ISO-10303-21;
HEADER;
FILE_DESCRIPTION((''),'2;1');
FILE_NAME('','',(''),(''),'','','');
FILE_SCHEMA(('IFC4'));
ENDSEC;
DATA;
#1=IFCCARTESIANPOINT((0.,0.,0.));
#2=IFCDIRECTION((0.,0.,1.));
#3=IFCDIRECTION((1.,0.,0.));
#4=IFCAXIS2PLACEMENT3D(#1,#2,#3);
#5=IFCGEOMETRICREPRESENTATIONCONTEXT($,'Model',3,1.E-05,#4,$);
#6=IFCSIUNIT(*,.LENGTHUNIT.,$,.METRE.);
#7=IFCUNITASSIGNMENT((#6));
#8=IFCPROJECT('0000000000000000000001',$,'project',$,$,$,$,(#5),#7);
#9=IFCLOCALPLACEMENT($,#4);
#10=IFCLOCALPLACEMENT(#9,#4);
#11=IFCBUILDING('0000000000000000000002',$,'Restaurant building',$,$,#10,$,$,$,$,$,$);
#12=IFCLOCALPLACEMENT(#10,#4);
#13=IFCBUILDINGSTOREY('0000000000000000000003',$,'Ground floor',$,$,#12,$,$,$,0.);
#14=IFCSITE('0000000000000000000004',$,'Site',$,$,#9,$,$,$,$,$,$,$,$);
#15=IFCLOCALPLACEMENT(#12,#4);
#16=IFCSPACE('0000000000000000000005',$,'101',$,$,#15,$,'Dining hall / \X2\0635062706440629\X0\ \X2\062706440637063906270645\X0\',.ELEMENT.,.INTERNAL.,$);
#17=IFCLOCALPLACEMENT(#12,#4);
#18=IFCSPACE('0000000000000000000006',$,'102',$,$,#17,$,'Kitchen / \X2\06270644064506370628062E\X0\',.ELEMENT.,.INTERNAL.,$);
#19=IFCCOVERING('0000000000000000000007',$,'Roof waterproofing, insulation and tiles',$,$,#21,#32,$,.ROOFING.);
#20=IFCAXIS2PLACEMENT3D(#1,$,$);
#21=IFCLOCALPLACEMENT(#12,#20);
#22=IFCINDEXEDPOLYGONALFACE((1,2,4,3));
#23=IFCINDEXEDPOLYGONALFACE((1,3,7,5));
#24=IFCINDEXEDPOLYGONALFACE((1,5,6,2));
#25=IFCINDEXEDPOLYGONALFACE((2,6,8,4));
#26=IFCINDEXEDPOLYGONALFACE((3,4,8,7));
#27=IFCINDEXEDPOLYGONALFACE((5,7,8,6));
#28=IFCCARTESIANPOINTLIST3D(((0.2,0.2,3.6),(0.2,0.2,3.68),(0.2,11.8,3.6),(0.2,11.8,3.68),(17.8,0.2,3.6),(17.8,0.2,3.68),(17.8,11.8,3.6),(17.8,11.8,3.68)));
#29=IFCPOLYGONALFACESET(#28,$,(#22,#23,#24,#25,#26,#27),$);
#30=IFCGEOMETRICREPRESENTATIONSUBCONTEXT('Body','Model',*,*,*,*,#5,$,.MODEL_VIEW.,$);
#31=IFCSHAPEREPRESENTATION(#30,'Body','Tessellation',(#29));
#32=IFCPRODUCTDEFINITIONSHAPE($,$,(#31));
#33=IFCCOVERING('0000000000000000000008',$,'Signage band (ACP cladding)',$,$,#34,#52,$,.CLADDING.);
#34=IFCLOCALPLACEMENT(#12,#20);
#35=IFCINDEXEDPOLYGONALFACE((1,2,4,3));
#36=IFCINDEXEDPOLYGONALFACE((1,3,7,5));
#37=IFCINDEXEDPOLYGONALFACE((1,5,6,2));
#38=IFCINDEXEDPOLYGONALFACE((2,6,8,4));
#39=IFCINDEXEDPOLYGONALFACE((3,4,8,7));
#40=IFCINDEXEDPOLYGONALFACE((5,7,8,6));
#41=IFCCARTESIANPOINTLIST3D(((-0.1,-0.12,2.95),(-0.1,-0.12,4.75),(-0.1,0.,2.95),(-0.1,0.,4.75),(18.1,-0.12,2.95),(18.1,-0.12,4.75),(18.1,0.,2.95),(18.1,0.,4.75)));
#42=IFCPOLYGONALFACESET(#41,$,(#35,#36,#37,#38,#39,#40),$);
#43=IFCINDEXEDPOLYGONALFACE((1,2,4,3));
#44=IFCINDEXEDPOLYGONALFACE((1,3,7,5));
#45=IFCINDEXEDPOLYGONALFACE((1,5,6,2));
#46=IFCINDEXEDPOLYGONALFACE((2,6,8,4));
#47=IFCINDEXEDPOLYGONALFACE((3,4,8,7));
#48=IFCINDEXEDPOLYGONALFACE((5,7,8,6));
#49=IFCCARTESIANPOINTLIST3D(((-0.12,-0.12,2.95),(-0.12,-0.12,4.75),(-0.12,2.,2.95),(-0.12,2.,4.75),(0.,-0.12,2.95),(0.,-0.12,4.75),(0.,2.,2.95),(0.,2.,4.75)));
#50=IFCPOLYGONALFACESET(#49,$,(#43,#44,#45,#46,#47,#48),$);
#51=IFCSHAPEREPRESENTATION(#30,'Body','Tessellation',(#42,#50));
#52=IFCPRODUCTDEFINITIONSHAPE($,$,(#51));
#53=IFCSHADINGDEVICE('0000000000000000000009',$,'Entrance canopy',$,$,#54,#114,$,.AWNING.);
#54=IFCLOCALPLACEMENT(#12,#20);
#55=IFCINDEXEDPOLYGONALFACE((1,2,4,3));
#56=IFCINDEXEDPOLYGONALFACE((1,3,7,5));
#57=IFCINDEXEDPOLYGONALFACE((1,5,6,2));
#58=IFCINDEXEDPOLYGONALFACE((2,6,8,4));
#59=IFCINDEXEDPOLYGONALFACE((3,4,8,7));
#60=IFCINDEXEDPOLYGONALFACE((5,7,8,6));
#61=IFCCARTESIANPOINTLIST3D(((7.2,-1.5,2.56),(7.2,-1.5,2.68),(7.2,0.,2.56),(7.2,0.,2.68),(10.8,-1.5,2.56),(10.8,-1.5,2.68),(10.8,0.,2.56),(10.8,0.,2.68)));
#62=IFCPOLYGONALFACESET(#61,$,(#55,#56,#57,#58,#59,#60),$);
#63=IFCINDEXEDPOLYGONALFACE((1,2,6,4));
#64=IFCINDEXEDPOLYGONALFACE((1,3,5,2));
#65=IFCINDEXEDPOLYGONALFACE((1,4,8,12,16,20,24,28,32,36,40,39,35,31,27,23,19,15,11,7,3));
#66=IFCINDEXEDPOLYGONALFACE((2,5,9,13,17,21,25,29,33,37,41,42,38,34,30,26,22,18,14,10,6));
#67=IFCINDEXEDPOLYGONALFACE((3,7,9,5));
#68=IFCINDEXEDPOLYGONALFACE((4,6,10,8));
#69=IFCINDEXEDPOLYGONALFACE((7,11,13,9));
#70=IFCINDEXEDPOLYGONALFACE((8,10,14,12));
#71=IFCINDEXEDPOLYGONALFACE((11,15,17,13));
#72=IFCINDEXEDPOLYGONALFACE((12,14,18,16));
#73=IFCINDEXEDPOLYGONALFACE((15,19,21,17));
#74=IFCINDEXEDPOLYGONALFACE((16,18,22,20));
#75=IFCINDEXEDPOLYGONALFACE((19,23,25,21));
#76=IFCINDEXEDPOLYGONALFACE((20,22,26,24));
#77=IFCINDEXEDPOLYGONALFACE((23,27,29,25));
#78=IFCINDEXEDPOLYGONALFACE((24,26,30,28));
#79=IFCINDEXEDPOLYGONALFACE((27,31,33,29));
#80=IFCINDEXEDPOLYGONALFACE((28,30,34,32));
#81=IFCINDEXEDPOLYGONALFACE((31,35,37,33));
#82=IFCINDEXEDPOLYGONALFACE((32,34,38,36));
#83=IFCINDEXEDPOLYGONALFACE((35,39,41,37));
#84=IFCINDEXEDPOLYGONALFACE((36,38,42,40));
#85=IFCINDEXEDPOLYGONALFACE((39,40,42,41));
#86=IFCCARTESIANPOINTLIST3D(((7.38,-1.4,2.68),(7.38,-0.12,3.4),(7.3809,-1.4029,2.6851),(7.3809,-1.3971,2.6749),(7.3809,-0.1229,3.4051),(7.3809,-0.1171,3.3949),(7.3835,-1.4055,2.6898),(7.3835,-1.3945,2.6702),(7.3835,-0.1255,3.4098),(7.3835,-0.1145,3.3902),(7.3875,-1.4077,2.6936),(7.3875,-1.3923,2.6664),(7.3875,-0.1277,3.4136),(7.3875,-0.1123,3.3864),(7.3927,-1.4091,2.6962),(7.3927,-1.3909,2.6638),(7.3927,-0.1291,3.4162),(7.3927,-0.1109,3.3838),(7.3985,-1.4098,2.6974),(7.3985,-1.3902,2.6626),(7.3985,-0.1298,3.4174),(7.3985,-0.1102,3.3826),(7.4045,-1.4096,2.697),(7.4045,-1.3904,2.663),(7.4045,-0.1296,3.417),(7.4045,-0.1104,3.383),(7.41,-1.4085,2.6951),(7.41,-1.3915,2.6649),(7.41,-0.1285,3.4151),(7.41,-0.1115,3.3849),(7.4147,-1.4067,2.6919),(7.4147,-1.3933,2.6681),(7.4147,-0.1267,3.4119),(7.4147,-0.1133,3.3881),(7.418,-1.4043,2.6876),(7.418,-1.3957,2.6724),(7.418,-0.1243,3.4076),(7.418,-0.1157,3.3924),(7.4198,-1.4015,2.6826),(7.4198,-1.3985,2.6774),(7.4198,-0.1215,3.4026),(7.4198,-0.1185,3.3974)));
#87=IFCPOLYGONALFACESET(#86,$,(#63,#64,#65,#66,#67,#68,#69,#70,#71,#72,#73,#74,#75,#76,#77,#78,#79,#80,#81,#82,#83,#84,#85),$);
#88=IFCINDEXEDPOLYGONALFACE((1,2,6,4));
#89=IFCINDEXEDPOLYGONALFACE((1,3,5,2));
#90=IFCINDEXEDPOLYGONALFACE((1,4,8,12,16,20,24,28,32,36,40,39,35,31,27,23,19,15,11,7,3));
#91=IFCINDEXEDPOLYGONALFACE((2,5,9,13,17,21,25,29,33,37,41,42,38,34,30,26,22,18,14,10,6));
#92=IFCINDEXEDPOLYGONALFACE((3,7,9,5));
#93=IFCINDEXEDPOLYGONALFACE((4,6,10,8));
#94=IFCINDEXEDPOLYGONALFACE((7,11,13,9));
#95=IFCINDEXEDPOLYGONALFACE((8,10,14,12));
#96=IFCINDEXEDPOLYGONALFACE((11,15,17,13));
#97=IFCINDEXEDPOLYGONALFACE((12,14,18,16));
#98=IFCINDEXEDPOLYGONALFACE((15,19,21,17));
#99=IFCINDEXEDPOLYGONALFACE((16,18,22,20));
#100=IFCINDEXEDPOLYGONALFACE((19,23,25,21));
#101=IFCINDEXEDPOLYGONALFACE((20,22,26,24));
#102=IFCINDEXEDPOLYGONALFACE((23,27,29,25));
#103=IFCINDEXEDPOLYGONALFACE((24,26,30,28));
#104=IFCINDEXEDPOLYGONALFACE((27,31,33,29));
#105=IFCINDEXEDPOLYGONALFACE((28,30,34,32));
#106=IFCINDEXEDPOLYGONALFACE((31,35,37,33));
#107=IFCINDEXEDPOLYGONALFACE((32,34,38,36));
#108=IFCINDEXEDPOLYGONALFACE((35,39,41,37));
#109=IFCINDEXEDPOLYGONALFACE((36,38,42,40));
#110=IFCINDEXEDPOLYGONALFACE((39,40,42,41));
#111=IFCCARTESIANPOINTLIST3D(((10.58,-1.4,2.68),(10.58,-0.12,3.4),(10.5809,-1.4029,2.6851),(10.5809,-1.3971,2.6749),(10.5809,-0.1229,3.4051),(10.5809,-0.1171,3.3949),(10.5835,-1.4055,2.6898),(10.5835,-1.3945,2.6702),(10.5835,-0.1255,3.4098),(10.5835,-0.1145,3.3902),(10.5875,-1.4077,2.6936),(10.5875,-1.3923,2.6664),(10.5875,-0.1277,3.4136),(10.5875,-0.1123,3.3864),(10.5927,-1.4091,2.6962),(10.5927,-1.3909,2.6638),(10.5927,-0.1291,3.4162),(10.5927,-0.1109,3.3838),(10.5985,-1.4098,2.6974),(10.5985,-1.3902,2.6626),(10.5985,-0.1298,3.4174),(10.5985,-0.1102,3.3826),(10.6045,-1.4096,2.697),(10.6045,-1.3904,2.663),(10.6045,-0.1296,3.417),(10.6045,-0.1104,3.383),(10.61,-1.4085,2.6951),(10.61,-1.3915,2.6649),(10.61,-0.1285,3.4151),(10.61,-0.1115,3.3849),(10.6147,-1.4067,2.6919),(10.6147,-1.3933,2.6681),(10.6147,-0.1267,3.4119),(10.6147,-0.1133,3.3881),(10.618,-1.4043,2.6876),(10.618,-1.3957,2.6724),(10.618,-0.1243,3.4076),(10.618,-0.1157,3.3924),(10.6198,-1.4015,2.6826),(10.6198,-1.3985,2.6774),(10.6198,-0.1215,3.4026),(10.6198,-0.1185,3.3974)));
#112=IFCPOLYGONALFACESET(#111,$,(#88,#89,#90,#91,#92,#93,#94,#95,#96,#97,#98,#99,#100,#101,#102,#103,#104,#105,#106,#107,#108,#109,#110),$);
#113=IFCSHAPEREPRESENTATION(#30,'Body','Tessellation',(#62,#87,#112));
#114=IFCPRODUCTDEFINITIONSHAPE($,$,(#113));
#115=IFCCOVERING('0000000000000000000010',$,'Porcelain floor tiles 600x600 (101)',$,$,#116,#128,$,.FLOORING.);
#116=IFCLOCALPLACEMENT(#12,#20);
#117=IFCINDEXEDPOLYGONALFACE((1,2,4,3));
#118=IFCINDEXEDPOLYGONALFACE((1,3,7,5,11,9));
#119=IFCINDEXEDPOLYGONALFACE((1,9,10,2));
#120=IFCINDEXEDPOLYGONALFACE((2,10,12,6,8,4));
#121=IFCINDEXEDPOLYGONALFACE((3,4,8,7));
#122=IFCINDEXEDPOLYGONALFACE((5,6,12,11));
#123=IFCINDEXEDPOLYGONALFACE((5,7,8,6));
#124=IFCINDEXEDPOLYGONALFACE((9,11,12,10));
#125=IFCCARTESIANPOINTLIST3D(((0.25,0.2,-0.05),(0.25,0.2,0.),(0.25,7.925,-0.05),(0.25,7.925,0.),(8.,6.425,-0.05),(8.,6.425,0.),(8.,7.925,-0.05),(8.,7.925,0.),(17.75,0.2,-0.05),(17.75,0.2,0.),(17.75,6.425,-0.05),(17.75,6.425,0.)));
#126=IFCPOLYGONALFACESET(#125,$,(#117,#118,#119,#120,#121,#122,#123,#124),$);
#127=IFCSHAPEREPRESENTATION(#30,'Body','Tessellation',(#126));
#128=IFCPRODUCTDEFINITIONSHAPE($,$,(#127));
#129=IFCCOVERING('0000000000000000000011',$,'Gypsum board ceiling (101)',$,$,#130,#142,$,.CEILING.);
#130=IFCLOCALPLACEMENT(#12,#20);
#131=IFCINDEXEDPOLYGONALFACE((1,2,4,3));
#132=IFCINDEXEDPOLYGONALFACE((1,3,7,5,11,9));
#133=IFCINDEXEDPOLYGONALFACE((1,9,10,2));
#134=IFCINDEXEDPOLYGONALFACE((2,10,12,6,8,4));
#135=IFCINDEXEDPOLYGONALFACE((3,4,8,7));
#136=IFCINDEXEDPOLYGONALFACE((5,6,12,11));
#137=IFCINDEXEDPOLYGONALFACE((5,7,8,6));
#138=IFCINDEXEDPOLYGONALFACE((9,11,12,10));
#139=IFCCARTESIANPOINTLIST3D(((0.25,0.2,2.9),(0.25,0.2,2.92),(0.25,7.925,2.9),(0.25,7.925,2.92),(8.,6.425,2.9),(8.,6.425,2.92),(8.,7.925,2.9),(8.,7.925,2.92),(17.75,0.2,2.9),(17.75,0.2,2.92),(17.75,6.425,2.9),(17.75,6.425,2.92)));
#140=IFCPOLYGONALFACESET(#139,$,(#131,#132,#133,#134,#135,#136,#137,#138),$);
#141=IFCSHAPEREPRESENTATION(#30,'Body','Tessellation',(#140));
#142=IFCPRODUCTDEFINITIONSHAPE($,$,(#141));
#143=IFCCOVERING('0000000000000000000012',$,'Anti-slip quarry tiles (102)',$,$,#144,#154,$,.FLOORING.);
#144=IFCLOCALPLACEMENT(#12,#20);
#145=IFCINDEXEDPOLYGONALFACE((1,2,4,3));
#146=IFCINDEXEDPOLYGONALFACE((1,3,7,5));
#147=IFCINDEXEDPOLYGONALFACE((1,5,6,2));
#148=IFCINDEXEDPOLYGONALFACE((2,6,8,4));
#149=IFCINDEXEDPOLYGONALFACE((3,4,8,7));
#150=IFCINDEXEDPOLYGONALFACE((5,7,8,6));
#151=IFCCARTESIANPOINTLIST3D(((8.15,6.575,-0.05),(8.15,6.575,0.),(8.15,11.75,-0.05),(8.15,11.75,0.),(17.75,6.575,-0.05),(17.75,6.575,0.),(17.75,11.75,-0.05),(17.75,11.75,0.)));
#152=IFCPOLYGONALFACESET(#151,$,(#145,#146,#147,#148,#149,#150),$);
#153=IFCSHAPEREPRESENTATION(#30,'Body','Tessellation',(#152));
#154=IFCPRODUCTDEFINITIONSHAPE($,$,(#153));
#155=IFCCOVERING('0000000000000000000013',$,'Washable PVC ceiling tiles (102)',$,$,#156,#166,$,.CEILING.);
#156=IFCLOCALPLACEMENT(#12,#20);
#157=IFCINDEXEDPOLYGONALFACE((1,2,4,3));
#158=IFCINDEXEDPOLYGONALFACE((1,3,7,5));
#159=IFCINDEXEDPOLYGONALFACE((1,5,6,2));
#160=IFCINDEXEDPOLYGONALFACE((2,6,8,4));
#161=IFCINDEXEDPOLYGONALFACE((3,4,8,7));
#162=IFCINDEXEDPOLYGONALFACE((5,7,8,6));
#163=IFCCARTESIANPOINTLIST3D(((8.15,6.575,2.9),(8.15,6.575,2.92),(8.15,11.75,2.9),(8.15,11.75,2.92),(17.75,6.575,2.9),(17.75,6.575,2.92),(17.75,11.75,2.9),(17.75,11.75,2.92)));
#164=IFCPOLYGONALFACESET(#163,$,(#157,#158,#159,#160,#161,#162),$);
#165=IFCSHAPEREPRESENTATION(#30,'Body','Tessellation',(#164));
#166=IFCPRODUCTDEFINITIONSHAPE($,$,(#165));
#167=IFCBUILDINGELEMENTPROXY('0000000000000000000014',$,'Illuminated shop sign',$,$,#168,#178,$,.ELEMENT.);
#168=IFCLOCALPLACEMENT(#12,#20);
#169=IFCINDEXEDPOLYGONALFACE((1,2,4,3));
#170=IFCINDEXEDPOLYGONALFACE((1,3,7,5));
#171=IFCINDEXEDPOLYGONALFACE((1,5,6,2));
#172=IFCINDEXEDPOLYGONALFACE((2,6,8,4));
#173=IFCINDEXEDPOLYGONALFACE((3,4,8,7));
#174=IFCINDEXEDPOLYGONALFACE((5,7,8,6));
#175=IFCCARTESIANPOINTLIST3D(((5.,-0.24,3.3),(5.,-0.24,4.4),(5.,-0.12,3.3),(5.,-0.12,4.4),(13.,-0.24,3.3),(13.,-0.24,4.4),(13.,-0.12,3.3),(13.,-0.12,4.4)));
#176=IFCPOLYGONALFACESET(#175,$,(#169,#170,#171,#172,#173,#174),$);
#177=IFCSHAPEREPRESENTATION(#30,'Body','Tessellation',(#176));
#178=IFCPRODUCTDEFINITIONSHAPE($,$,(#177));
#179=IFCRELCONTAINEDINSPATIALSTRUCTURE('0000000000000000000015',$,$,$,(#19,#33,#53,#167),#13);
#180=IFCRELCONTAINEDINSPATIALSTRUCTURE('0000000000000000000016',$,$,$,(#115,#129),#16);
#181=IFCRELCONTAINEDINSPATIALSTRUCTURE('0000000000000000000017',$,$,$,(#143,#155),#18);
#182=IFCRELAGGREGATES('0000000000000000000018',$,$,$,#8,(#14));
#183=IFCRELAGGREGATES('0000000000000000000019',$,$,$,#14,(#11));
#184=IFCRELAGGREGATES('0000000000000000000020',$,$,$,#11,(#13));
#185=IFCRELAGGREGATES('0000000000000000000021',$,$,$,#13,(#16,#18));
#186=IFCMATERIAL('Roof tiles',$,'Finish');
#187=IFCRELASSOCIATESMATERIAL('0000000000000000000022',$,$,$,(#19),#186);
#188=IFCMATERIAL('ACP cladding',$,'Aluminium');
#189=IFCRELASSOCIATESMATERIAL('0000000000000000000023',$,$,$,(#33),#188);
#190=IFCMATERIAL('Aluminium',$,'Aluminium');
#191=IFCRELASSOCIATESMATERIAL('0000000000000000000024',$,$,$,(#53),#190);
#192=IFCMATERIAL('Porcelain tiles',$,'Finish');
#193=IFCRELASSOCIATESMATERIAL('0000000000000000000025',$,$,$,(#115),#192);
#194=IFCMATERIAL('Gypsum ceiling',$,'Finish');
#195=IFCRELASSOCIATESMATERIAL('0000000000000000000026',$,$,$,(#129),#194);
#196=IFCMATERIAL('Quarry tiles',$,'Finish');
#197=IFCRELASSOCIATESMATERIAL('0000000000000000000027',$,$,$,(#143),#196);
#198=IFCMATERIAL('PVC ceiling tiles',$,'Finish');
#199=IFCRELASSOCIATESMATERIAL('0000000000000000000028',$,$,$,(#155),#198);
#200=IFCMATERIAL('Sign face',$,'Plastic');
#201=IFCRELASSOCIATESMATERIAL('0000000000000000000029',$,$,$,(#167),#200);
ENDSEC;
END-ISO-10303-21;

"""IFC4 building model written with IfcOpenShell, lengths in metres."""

from ifc_helpers import new_model, si_unit, frame, origin, origin_with_axes, origin_2d, place, context, subcontext, project, spatial, polyline, rectangle, circle, outline, extrude, material, element, save


model = new_model("IFC4")

# Units and contexts
model_context = context("Model", 3, precision=1e-05, world=origin_with_axes())
body_context = subcontext(model_context, "Body", "Model", "MODEL_VIEW")
ifc_project = project(units=[si_unit("LENGTHUNIT", "METRE")], contexts=[model_context])

# Site, building, storey
site_placement = place(None, origin_with_axes())
site = spatial("IfcSite", under=ifc_project, at=site_placement, Name="Site")
building_placement = place(site_placement, origin_with_axes())
building = spatial("IfcBuilding", under=site, at=building_placement, Name="Restaurant building")
storey_placement = place(building_placement, origin_with_axes())
storey = spatial("IfcBuildingStorey", under=building, at=storey_placement, Name="Ground floor", Elevation=0.0)

# Coverings
ifc_material_1 = material(Name="Roof tiles", Category="Finish")
covering_1_placement = place(storey_placement, origin())
element("IfcCovering", 1, at=covering_1_placement, inside=storey, material=ifc_material_1, Name="Roof waterproofing, insulation and tiles", PredefinedType="ROOFING", context=body_context, shape_type="SweptSolid", body=[
    extrude(rectangle(XDim=17.6, YDim=11.6, at=origin_2d()), frame((9.0, 6.0, 3.6)), (0.0, 0.0, 1.0), 0.08),
])
ifc_material_2 = material(Name="ACP cladding", Category="Aluminium")
covering_2_placement = place(storey_placement, origin())
element("IfcCovering", 2, at=covering_2_placement, inside=storey, material=ifc_material_2, Name="Signage band (ACP cladding)", PredefinedType="CLADDING", context=body_context, shape_type="SweptSolid", body=[
    extrude(rectangle(XDim=18.2, YDim=0.12, at=origin_2d()), frame((9.0, -0.06, 2.95)), (0.0, 0.0, 1.0), 1.8),
    extrude(rectangle(XDim=0.12, YDim=2.12, at=origin_2d()), frame((-0.06, 0.94, 2.95)), (0.0, 0.0, 1.0), 1.8),
])

# Shading device
ifc_material_3 = material(Name="Aluminium", Category="Aluminium")
shading_device_placement = place(storey_placement, origin())
element("IfcShadingDevice", 3, at=shading_device_placement, inside=storey, material=ifc_material_3, Name="Entrance canopy", PredefinedType="AWNING", context=body_context, shape_type="SweptSolid", body=[
    extrude(rectangle(XDim=3.6, YDim=1.5, at=origin_2d()), frame((9.0, -0.75, 2.56)), (0.0, 0.0, 1.0), 0.12),
    extrude(circle(Radius=0.02, at=origin_2d()), frame((7.4, -1.4, 2.68), z_axis=(0.0, 0.871576, 0.490261), x_axis=(-1.0, 0.0, 0.0)), (0.0, 0.0, 1.0), 1.4686),
    extrude(circle(Radius=0.02, at=origin_2d()), frame((10.6, -1.4, 2.68), z_axis=(0.0, 0.871576, 0.490261), x_axis=(-1.0, 0.0, 0.0)), (0.0, 0.0, 1.0), 1.4686),
])

# Shared definitions
space_1_placement = place(storey_placement, origin_with_axes())
space_1 = spatial("IfcSpace", under=storey, at=space_1_placement, Name="101", LongName="Dining hall / صالة الطعام", CompositionType="ELEMENT", PredefinedType="INTERNAL")

# Coverings
ifc_material_4 = material(Name="Porcelain tiles", Category="Finish")
covering_3_placement = place(storey_placement, origin())
element("IfcCovering", 4, at=covering_3_placement, inside=space_1, material=ifc_material_4, Name="Porcelain floor tiles 600x600 (101)", PredefinedType="FLOORING", context=body_context, shape_type="SweptSolid", body=[
    extrude(outline(polyline([(0.25, 0.2), (17.75, 0.2), (17.75, 6.425), (8.0, 6.425), (8.0, 7.925), (0.25, 7.925), (0.25, 0.2)])), frame((0.0, 0.0, -0.05)), (0.0, 0.0, 1.0), 0.05),
])
ifc_material_5 = material(Name="Gypsum ceiling", Category="Finish")
covering_4_placement = place(storey_placement, origin())
element("IfcCovering", 5, at=covering_4_placement, inside=space_1, material=ifc_material_5, Name="Gypsum board ceiling (101)", PredefinedType="CEILING", context=body_context, shape_type="SweptSolid", body=[
    extrude(outline(polyline([(0.25, 0.2), (17.75, 0.2), (17.75, 6.425), (8.0, 6.425), (8.0, 7.925), (0.25, 7.925), (0.25, 0.2)])), frame((0.0, 0.0, 2.9)), (0.0, 0.0, 1.0), 0.02),
])

# Shared definitions
space_2_placement = place(storey_placement, origin_with_axes())
space_2 = spatial("IfcSpace", under=storey, at=space_2_placement, Name="102", LongName="Kitchen / المطبخ", CompositionType="ELEMENT", PredefinedType="INTERNAL")

# Coverings
ifc_material_6 = material(Name="Quarry tiles", Category="Finish")
covering_5_placement = place(storey_placement, origin())
element("IfcCovering", 6, at=covering_5_placement, inside=space_2, material=ifc_material_6, Name="Anti-slip quarry tiles (102)", PredefinedType="FLOORING", context=body_context, shape_type="SweptSolid", body=[
    extrude(outline(polyline([(8.15, 6.575), (17.75, 6.575), (17.75, 11.75), (8.15, 11.75), (8.15, 6.575)])), frame((0.0, 0.0, -0.05)), (0.0, 0.0, 1.0), 0.05),
])
ifc_material_7 = material(Name="PVC ceiling tiles", Category="Finish")
covering_6_placement = place(storey_placement, origin())
element("IfcCovering", 7, at=covering_6_placement, inside=space_2, material=ifc_material_7, Name="Washable PVC ceiling tiles (102)", PredefinedType="CEILING", context=body_context, shape_type="SweptSolid", body=[
    extrude(outline(polyline([(8.15, 6.575), (17.75, 6.575), (17.75, 11.75), (8.15, 11.75), (8.15, 6.575)])), frame((0.0, 0.0, 2.9)), (0.0, 0.0, 1.0), 0.02),
])

# Building element proxy
ifc_material_8 = material(Name="Sign face", Category="Plastic")
proxy_placement = place(storey_placement, origin())
element("IfcBuildingElementProxy", 8, at=proxy_placement, inside=storey, material=ifc_material_8, Name="Illuminated shop sign", PredefinedType="ELEMENT", context=body_context, shape_type="SweptSolid", body=[
    extrude(rectangle(XDim=8.0, YDim=0.12, at=origin_2d()), frame((9.0, -0.18, 3.3)), (0.0, 0.0, 1.0), 1.1),
])

save(model, "model.ifc")
